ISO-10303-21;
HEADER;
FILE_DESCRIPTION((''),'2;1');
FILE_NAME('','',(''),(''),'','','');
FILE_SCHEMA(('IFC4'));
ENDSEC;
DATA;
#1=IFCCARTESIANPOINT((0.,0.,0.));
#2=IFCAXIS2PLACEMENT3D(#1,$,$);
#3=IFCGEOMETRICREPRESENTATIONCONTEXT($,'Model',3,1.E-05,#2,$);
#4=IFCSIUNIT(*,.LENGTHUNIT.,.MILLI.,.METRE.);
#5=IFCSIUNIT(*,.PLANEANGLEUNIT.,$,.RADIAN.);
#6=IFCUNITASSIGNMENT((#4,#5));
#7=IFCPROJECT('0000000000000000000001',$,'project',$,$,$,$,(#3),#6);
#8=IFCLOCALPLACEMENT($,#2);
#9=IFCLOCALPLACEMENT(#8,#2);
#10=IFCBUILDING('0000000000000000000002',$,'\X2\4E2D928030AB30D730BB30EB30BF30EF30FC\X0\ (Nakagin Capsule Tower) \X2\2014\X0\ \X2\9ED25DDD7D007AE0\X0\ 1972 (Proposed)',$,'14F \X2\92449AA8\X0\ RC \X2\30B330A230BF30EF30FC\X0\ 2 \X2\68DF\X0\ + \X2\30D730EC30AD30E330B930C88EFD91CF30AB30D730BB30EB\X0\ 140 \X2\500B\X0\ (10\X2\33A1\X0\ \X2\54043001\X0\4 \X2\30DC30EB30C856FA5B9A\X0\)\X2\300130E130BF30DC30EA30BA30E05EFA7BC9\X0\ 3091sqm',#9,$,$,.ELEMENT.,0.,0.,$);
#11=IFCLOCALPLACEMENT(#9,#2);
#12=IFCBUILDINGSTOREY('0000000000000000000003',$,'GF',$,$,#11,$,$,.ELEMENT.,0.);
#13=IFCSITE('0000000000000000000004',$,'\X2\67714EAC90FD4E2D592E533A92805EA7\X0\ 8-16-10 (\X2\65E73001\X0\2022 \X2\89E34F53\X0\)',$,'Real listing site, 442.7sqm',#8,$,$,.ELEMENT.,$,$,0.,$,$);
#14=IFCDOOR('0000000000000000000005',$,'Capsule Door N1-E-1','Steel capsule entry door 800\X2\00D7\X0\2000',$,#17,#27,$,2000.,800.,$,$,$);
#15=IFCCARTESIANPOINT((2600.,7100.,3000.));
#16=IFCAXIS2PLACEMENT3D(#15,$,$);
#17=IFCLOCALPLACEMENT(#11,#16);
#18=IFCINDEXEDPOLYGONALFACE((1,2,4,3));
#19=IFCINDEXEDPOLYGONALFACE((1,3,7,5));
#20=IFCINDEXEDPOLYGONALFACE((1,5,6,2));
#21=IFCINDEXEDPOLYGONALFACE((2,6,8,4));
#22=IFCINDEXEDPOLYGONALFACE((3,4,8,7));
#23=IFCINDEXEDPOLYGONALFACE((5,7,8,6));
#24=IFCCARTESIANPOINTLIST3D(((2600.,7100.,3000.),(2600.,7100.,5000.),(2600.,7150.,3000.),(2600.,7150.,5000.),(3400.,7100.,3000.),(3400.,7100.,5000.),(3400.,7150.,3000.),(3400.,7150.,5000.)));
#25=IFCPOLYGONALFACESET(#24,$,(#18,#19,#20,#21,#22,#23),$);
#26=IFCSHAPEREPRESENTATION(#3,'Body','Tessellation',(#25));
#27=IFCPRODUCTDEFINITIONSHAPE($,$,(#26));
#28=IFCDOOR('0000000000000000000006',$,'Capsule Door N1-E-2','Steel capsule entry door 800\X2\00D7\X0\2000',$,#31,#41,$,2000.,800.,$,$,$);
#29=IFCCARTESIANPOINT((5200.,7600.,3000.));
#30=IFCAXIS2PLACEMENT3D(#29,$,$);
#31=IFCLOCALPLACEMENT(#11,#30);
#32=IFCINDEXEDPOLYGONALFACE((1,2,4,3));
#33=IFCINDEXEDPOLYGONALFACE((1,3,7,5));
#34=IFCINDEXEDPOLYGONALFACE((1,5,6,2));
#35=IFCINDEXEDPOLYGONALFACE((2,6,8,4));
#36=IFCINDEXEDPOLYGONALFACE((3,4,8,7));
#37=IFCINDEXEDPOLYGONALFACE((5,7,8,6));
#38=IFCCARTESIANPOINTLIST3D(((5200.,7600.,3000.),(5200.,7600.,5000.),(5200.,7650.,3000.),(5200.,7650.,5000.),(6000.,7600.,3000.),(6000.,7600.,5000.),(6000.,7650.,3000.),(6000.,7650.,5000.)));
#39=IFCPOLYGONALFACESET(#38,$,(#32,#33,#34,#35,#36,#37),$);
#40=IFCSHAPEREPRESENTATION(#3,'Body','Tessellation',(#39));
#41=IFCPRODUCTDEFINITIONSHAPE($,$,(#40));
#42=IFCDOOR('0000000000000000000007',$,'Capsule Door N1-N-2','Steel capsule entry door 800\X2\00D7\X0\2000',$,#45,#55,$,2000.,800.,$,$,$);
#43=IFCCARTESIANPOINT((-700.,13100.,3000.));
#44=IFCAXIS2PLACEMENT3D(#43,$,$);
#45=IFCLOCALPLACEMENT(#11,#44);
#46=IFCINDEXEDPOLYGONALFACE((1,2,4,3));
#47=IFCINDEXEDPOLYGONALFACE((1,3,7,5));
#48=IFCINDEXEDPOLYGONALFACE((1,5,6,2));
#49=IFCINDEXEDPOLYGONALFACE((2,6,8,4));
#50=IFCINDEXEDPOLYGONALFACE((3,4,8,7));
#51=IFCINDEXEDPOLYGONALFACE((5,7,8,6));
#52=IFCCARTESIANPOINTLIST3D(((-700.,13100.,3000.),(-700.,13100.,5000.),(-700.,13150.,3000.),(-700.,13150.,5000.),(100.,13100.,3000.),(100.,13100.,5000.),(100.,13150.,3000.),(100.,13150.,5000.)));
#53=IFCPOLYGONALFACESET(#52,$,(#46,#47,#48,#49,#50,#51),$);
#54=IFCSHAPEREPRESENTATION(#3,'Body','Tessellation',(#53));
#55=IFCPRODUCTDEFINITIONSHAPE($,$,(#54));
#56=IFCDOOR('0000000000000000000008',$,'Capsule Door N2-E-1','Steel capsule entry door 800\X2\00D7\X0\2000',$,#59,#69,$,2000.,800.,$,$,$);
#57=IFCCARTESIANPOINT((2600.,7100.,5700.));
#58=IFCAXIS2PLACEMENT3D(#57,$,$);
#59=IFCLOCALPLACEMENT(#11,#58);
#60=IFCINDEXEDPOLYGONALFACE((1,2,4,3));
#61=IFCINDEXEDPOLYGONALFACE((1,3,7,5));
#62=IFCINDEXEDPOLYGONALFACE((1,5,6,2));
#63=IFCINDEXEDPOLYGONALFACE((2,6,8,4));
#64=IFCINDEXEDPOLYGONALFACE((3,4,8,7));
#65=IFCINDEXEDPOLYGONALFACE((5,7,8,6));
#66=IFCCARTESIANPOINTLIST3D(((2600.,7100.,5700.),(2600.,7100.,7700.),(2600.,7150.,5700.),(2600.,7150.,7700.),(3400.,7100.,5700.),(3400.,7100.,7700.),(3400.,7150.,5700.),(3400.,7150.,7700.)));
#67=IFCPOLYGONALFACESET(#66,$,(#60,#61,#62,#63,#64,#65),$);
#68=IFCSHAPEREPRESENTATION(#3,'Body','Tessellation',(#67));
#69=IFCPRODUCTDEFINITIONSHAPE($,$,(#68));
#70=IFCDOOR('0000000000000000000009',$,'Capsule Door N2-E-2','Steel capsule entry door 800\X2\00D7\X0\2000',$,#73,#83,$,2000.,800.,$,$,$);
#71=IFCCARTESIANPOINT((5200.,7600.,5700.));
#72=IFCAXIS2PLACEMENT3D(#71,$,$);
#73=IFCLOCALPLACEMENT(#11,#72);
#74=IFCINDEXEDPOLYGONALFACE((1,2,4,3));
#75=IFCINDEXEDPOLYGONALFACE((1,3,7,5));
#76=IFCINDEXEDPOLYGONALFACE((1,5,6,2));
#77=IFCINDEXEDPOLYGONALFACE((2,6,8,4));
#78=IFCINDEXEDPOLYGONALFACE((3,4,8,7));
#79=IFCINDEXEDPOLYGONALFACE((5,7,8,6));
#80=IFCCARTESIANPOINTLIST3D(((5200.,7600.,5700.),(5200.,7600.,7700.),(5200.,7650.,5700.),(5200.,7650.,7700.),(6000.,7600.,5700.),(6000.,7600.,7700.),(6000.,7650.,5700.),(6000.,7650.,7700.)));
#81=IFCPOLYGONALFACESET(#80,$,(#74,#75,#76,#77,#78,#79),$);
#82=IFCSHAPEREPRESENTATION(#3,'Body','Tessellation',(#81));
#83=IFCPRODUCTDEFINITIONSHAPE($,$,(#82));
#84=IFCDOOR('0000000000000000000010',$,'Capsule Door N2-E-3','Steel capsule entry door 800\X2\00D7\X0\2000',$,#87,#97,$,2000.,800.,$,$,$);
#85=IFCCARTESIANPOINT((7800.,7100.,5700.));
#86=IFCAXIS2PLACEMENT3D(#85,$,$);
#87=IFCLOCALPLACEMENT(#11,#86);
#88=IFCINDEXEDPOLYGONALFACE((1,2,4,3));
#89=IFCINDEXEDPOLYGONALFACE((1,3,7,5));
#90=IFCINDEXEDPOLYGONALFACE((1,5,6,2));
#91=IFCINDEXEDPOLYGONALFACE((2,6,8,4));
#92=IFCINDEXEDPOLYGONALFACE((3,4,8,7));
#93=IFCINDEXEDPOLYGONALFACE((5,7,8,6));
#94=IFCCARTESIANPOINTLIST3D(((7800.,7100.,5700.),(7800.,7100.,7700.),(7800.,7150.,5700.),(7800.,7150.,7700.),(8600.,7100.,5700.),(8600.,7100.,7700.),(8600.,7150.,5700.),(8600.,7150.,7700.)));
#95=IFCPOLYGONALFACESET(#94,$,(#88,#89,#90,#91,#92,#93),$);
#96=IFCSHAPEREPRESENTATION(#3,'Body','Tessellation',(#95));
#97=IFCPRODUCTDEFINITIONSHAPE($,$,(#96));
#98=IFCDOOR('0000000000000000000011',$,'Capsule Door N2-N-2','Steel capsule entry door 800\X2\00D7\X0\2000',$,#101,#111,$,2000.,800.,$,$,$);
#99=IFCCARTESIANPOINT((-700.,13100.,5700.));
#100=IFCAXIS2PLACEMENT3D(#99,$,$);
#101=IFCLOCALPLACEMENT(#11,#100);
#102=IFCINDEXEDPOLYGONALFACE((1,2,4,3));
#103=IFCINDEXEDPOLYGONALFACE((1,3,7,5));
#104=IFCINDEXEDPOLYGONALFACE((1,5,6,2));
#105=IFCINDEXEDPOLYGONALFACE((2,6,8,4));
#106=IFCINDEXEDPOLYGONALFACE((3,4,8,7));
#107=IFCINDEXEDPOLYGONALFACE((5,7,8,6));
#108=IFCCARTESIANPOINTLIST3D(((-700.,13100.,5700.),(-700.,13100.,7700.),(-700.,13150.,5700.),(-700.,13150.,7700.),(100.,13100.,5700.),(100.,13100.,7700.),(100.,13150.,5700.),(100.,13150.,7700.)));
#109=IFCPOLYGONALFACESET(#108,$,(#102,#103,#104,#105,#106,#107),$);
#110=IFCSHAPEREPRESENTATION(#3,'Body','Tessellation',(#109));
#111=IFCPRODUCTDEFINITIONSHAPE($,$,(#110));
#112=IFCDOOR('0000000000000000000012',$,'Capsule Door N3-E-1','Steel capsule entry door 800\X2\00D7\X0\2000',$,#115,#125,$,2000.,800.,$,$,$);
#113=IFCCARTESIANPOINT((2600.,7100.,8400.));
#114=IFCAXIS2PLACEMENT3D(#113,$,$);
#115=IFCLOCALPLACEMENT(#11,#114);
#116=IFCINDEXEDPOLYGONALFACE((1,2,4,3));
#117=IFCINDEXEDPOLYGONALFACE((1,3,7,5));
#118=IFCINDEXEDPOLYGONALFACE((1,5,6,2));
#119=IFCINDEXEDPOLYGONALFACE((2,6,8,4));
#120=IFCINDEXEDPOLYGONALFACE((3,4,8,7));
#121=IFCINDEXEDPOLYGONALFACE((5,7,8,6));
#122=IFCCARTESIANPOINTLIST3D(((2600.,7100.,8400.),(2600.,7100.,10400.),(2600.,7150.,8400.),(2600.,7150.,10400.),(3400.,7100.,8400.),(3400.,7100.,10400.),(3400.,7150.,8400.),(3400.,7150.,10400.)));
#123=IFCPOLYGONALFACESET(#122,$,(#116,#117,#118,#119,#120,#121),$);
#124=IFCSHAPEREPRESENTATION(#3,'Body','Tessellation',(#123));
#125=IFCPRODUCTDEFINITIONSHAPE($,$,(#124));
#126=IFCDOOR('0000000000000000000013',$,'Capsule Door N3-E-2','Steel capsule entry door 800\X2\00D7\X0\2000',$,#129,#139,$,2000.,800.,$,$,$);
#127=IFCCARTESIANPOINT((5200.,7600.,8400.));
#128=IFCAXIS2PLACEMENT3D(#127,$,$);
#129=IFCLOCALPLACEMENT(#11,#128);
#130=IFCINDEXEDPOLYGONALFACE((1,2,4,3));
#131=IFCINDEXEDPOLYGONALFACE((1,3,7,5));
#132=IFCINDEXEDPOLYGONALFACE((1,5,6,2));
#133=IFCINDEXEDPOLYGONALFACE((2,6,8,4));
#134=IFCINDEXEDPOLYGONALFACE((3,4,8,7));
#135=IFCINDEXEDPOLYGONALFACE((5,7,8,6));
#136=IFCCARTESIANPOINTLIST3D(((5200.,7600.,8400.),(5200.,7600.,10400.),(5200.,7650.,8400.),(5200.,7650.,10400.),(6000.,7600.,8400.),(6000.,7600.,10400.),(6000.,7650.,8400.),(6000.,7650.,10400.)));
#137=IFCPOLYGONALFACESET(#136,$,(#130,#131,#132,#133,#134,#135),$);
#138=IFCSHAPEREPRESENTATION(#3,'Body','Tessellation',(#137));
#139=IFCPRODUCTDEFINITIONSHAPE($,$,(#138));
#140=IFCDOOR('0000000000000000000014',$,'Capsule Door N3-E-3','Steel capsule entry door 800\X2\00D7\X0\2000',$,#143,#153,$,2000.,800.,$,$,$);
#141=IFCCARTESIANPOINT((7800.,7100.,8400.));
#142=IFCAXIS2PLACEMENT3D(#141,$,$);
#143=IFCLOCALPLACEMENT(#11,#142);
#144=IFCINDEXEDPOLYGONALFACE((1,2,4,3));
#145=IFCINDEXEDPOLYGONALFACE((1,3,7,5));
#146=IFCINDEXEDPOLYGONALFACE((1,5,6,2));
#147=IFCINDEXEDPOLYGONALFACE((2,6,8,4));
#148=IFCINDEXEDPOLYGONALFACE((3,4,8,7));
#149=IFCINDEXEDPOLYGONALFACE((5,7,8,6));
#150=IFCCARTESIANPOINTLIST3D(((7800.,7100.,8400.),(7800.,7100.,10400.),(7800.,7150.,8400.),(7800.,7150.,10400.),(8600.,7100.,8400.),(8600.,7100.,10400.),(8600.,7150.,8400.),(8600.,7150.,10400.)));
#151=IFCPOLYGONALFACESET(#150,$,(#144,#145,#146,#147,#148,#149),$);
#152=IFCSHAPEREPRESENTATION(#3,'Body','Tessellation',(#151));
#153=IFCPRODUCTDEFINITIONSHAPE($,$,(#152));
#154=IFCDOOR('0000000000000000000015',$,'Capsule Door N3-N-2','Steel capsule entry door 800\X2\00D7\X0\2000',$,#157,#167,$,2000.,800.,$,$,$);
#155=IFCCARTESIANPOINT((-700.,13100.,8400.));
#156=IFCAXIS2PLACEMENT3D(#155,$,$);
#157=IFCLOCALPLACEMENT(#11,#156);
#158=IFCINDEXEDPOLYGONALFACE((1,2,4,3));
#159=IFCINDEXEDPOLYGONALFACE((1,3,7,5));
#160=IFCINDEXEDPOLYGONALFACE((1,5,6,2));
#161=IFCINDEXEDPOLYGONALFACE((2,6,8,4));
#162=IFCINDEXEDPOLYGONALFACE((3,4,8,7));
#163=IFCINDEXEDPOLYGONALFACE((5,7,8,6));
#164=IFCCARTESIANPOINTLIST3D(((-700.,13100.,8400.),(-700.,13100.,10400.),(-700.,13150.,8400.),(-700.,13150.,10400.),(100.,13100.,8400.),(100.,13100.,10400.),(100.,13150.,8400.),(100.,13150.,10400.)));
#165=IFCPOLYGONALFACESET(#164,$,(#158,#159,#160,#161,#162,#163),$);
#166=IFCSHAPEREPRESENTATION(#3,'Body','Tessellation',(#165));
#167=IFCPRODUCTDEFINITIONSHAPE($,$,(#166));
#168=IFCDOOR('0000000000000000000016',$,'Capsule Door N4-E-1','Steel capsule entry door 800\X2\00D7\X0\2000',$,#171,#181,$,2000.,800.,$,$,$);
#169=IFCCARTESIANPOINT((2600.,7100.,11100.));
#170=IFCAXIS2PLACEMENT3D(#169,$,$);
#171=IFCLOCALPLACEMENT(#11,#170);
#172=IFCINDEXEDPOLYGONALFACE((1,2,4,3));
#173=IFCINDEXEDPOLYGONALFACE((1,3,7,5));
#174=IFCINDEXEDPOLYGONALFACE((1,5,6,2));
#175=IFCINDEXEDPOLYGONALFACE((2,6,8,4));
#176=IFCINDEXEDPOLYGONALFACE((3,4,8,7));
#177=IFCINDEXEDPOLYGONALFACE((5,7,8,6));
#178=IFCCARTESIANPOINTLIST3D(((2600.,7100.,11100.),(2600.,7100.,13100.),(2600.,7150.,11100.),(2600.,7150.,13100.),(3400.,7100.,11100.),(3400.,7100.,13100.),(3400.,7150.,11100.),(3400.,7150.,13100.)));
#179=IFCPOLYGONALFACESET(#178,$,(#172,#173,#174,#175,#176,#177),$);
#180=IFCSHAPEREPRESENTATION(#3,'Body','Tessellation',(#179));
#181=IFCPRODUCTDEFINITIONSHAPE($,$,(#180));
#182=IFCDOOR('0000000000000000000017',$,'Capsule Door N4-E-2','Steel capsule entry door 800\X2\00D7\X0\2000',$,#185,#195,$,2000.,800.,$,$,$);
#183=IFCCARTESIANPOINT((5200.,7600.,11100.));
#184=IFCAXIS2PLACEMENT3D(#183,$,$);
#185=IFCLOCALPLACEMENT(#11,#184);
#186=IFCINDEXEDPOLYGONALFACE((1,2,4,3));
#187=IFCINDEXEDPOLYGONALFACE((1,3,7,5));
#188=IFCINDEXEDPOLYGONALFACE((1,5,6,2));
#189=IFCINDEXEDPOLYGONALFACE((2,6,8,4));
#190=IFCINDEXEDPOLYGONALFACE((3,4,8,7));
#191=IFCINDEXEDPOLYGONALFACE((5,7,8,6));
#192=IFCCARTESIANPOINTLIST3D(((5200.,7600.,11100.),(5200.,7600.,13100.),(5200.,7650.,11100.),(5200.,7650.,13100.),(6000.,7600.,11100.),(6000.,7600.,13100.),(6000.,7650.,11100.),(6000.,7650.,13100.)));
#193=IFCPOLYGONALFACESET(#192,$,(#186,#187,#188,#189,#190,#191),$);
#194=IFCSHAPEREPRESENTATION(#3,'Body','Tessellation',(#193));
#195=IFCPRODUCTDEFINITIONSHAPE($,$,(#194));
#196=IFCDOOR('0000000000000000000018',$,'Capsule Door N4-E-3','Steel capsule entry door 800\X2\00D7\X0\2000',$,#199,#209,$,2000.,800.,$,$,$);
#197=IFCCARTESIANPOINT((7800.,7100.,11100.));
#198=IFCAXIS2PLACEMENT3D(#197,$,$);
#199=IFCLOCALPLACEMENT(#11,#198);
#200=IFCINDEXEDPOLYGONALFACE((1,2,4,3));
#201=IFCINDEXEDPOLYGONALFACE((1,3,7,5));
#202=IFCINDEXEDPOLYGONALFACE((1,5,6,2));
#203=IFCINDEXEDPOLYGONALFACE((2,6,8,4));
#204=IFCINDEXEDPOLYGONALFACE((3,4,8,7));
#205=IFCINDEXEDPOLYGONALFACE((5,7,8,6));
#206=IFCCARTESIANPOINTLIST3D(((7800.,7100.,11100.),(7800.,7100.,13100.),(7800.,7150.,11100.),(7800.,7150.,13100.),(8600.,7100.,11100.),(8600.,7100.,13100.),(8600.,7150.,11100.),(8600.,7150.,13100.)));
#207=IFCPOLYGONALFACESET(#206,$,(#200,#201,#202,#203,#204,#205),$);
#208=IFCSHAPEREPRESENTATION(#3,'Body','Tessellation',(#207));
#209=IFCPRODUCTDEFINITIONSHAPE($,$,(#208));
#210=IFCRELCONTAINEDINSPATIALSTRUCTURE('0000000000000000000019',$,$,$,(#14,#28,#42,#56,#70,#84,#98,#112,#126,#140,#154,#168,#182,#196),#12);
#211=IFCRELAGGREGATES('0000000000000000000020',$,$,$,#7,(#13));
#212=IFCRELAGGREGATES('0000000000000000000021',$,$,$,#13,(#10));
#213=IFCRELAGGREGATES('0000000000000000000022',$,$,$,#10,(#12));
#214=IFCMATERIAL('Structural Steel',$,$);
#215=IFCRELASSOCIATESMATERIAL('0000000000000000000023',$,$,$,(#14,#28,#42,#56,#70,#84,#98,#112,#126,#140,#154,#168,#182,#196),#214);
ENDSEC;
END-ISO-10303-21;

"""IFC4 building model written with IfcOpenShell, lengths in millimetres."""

from ifc_helpers import new_model, si_unit, frame, frame_2d, origin, place, context, project, spatial, rectangle, extrude, material, element, save


model = new_model("IFC4")

# Units and contexts
model_context = context("Model", 3, precision=1e-05, world=origin())
ifc_project = project(units=[si_unit("LENGTHUNIT", "METRE", prefix="MILLI"), si_unit("PLANEANGLEUNIT", "RADIAN")], contexts=[model_context])

# Site, building, storey
site_placement = place(None, origin())
site = spatial("IfcSite", under=ifc_project, at=site_placement, Name="東京都中央区銀座 8-16-10 (旧、2022 解体)", ObjectType="Real listing site, 442.7sqm", CompositionType="ELEMENT", RefElevation=0.0)
building_placement = place(site_placement, origin())
building = spatial("IfcBuilding", under=site, at=building_placement, Name="中銀カプセルタワー (Nakagin Capsule Tower) — 黒川紀章 1972 (Proposed)", ObjectType="14F 鉄骨 RC コアタワー 2 棟 + プレキャスト軽量カプセル 140 個 (10㎡ 各、4 ボルト固定)、メタボリズム建築 3091sqm", CompositionType="ELEMENT", ElevationOfRefHeight=0.0, ElevationOfTerrain=0.0)
storey_placement = place(building_placement, origin())
storey = spatial("IfcBuildingStorey", under=building, at=storey_placement, Name="GF", CompositionType="ELEMENT", Elevation=0.0)

# Doors
ifc_material_1 = material(Name="Structural Steel")
door_1_placement = place(storey_placement, frame((2600.0, 7100.0, 3000.0)))
element("IfcDoor", 1, at=door_1_placement, inside=storey, material=ifc_material_1, Name="Capsule Door N1-E-1", Description="Steel capsule entry door 800×2000", OverallHeight=2000.0, OverallWidth=800.0, context=model_context, shape_type="SweptSolid", body=[
    extrude(rectangle(XDim=800.0, YDim=50.0, at=frame_2d((400.0, 25.0))), frame((2600.0, 7100.0, 3000.0)), (0.0, 0.0, 1.0), 2000.0),
])
door_2_placement = place(storey_placement, frame((5200.0, 7600.0, 3000.0)))
element("IfcDoor", 2, at=door_2_placement, inside=storey, material=ifc_material_1, Name="Capsule Door N1-E-2", Description="Steel capsule entry door 800×2000", OverallHeight=2000.0, OverallWidth=800.0, context=model_context, shape_type="SweptSolid", body=[
    extrude(rectangle(XDim=800.0, YDim=50.0, at=frame_2d((400.0, 25.0))), frame((5200.0, 7600.0, 3000.0)), (0.0, 0.0, 1.0), 2000.0),
])
door_3_placement = place(storey_placement, frame((-700.0, 13100.0, 3000.0)))
element("IfcDoor", 3, at=door_3_placement, inside=storey, material=ifc_material_1, Name="Capsule Door N1-N-2", Description="Steel capsule entry door 800×2000", OverallHeight=2000.0, OverallWidth=800.0, context=model_context, shape_type="SweptSolid", body=[
    extrude(rectangle(XDim=800.0, YDim=50.0, at=frame_2d((400.0, 25.0))), frame((-700.0, 13100.0, 3000.0)), (0.0, 0.0, 1.0), 2000.0),
])
door_4_placement = place(storey_placement, frame((2600.0, 7100.0, 5700.0)))
element("IfcDoor", 4, at=door_4_placement, inside=storey, material=ifc_material_1, Name="Capsule Door N2-E-1", Description="Steel capsule entry door 800×2000", OverallHeight=2000.0, OverallWidth=800.0, context=model_context, shape_type="SweptSolid", body=[
    extrude(rectangle(XDim=800.0, YDim=50.0, at=frame_2d((400.0, 25.0))), frame((2600.0, 7100.0, 5700.0)), (0.0, 0.0, 1.0), 2000.0),
])
door_5_placement = place(storey_placement, frame((5200.0, 7600.0, 5700.0)))
element("IfcDoor", 5, at=door_5_placement, inside=storey, material=ifc_material_1, Name="Capsule Door N2-E-2", Description="Steel capsule entry door 800×2000", OverallHeight=2000.0, OverallWidth=800.0, context=model_context, shape_type="SweptSolid", body=[
    extrude(rectangle(XDim=800.0, YDim=50.0, at=frame_2d((400.0, 25.0))), frame((5200.0, 7600.0, 5700.0)), (0.0, 0.0, 1.0), 2000.0),
])
door_6_placement = place(storey_placement, frame((7800.0, 7100.0, 5700.0)))
element("IfcDoor", 6, at=door_6_placement, inside=storey, material=ifc_material_1, Name="Capsule Door N2-E-3", Description="Steel capsule entry door 800×2000", OverallHeight=2000.0, OverallWidth=800.0, context=model_context, shape_type="SweptSolid", body=[
    extrude(rectangle(XDim=800.0, YDim=50.0, at=frame_2d((400.0, 25.0))), frame((7800.0, 7100.0, 5700.0)), (0.0, 0.0, 1.0), 2000.0),
])
door_7_placement = place(storey_placement, frame((-700.0, 13100.0, 5700.0)))
element("IfcDoor", 7, at=door_7_placement, inside=storey, material=ifc_material_1, Name="Capsule Door N2-N-2", Description="Steel capsule entry door 800×2000", OverallHeight=2000.0, OverallWidth=800.0, context=model_context, shape_type="SweptSolid", body=[
    extrude(rectangle(XDim=800.0, YDim=50.0, at=frame_2d((400.0, 25.0))), frame((-700.0, 13100.0, 5700.0)), (0.0, 0.0, 1.0), 2000.0),
])
door_8_placement = place(storey_placement, frame((2600.0, 7100.0, 8400.0)))
element("IfcDoor", 8, at=door_8_placement, inside=storey, material=ifc_material_1, Name="Capsule Door N3-E-1", Description="Steel capsule entry door 800×2000", OverallHeight=2000.0, OverallWidth=800.0, context=model_context, shape_type="SweptSolid", body=[
    extrude(rectangle(XDim=800.0, YDim=50.0, at=frame_2d((400.0, 25.0))), frame((2600.0, 7100.0, 8400.0)), (0.0, 0.0, 1.0), 2000.0),
])
door_9_placement = place(storey_placement, frame((5200.0, 7600.0, 8400.0)))
element("IfcDoor", 9, at=door_9_placement, inside=storey, material=ifc_material_1, Name="Capsule Door N3-E-2", Description="Steel capsule entry door 800×2000", OverallHeight=2000.0, OverallWidth=800.0, context=model_context, shape_type="SweptSolid", body=[
    extrude(rectangle(XDim=800.0, YDim=50.0, at=frame_2d((400.0, 25.0))), frame((5200.0, 7600.0, 8400.0)), (0.0, 0.0, 1.0), 2000.0),
])
door_10_placement = place(storey_placement, frame((7800.0, 7100.0, 8400.0)))
element("IfcDoor", 10, at=door_10_placement, inside=storey, material=ifc_material_1, Name="Capsule Door N3-E-3", Description="Steel capsule entry door 800×2000", OverallHeight=2000.0, OverallWidth=800.0, context=model_context, shape_type="SweptSolid", body=[
    extrude(rectangle(XDim=800.0, YDim=50.0, at=frame_2d((400.0, 25.0))), frame((7800.0, 7100.0, 8400.0)), (0.0, 0.0, 1.0), 2000.0),
])
door_11_placement = place(storey_placement, frame((-700.0, 13100.0, 8400.0)))
element("IfcDoor", 11, at=door_11_placement, inside=storey, material=ifc_material_1, Name="Capsule Door N3-N-2", Description="Steel capsule entry door 800×2000", OverallHeight=2000.0, OverallWidth=800.0, context=model_context, shape_type="SweptSolid", body=[
    extrude(rectangle(XDim=800.0, YDim=50.0, at=frame_2d((400.0, 25.0))), frame((-700.0, 13100.0, 8400.0)), (0.0, 0.0, 1.0), 2000.0),
])
door_12_placement = place(storey_placement, frame((2600.0, 7100.0, 11100.0)))
element("IfcDoor", 12, at=door_12_placement, inside=storey, material=ifc_material_1, Name="Capsule Door N4-E-1", Description="Steel capsule entry door 800×2000", OverallHeight=2000.0, OverallWidth=800.0, context=model_context, shape_type="SweptSolid", body=[
    extrude(rectangle(XDim=800.0, YDim=50.0, at=frame_2d((400.0, 25.0))), frame((2600.0, 7100.0, 11100.0)), (0.0, 0.0, 1.0), 2000.0),
])
door_13_placement = place(storey_placement, frame((5200.0, 7600.0, 11100.0)))
element("IfcDoor", 13, at=door_13_placement, inside=storey, material=ifc_material_1, Name="Capsule Door N4-E-2", Description="Steel capsule entry door 800×2000", OverallHeight=2000.0, OverallWidth=800.0, context=model_context, shape_type="SweptSolid", body=[
    extrude(rectangle(XDim=800.0, YDim=50.0, at=frame_2d((400.0, 25.0))), frame((5200.0, 7600.0, 11100.0)), (0.0, 0.0, 1.0), 2000.0),
])
door_14_placement = place(storey_placement, frame((7800.0, 7100.0, 11100.0)))
element("IfcDoor", 14, at=door_14_placement, inside=storey, material=ifc_material_1, Name="Capsule Door N4-E-3", Description="Steel capsule entry door 800×2000", OverallHeight=2000.0, OverallWidth=800.0, context=model_context, shape_type="SweptSolid", body=[
    extrude(rectangle(XDim=800.0, YDim=50.0, at=frame_2d((400.0, 25.0))), frame((7800.0, 7100.0, 11100.0)), (0.0, 0.0, 1.0), 2000.0),
])

save(model, "model.ifc")
